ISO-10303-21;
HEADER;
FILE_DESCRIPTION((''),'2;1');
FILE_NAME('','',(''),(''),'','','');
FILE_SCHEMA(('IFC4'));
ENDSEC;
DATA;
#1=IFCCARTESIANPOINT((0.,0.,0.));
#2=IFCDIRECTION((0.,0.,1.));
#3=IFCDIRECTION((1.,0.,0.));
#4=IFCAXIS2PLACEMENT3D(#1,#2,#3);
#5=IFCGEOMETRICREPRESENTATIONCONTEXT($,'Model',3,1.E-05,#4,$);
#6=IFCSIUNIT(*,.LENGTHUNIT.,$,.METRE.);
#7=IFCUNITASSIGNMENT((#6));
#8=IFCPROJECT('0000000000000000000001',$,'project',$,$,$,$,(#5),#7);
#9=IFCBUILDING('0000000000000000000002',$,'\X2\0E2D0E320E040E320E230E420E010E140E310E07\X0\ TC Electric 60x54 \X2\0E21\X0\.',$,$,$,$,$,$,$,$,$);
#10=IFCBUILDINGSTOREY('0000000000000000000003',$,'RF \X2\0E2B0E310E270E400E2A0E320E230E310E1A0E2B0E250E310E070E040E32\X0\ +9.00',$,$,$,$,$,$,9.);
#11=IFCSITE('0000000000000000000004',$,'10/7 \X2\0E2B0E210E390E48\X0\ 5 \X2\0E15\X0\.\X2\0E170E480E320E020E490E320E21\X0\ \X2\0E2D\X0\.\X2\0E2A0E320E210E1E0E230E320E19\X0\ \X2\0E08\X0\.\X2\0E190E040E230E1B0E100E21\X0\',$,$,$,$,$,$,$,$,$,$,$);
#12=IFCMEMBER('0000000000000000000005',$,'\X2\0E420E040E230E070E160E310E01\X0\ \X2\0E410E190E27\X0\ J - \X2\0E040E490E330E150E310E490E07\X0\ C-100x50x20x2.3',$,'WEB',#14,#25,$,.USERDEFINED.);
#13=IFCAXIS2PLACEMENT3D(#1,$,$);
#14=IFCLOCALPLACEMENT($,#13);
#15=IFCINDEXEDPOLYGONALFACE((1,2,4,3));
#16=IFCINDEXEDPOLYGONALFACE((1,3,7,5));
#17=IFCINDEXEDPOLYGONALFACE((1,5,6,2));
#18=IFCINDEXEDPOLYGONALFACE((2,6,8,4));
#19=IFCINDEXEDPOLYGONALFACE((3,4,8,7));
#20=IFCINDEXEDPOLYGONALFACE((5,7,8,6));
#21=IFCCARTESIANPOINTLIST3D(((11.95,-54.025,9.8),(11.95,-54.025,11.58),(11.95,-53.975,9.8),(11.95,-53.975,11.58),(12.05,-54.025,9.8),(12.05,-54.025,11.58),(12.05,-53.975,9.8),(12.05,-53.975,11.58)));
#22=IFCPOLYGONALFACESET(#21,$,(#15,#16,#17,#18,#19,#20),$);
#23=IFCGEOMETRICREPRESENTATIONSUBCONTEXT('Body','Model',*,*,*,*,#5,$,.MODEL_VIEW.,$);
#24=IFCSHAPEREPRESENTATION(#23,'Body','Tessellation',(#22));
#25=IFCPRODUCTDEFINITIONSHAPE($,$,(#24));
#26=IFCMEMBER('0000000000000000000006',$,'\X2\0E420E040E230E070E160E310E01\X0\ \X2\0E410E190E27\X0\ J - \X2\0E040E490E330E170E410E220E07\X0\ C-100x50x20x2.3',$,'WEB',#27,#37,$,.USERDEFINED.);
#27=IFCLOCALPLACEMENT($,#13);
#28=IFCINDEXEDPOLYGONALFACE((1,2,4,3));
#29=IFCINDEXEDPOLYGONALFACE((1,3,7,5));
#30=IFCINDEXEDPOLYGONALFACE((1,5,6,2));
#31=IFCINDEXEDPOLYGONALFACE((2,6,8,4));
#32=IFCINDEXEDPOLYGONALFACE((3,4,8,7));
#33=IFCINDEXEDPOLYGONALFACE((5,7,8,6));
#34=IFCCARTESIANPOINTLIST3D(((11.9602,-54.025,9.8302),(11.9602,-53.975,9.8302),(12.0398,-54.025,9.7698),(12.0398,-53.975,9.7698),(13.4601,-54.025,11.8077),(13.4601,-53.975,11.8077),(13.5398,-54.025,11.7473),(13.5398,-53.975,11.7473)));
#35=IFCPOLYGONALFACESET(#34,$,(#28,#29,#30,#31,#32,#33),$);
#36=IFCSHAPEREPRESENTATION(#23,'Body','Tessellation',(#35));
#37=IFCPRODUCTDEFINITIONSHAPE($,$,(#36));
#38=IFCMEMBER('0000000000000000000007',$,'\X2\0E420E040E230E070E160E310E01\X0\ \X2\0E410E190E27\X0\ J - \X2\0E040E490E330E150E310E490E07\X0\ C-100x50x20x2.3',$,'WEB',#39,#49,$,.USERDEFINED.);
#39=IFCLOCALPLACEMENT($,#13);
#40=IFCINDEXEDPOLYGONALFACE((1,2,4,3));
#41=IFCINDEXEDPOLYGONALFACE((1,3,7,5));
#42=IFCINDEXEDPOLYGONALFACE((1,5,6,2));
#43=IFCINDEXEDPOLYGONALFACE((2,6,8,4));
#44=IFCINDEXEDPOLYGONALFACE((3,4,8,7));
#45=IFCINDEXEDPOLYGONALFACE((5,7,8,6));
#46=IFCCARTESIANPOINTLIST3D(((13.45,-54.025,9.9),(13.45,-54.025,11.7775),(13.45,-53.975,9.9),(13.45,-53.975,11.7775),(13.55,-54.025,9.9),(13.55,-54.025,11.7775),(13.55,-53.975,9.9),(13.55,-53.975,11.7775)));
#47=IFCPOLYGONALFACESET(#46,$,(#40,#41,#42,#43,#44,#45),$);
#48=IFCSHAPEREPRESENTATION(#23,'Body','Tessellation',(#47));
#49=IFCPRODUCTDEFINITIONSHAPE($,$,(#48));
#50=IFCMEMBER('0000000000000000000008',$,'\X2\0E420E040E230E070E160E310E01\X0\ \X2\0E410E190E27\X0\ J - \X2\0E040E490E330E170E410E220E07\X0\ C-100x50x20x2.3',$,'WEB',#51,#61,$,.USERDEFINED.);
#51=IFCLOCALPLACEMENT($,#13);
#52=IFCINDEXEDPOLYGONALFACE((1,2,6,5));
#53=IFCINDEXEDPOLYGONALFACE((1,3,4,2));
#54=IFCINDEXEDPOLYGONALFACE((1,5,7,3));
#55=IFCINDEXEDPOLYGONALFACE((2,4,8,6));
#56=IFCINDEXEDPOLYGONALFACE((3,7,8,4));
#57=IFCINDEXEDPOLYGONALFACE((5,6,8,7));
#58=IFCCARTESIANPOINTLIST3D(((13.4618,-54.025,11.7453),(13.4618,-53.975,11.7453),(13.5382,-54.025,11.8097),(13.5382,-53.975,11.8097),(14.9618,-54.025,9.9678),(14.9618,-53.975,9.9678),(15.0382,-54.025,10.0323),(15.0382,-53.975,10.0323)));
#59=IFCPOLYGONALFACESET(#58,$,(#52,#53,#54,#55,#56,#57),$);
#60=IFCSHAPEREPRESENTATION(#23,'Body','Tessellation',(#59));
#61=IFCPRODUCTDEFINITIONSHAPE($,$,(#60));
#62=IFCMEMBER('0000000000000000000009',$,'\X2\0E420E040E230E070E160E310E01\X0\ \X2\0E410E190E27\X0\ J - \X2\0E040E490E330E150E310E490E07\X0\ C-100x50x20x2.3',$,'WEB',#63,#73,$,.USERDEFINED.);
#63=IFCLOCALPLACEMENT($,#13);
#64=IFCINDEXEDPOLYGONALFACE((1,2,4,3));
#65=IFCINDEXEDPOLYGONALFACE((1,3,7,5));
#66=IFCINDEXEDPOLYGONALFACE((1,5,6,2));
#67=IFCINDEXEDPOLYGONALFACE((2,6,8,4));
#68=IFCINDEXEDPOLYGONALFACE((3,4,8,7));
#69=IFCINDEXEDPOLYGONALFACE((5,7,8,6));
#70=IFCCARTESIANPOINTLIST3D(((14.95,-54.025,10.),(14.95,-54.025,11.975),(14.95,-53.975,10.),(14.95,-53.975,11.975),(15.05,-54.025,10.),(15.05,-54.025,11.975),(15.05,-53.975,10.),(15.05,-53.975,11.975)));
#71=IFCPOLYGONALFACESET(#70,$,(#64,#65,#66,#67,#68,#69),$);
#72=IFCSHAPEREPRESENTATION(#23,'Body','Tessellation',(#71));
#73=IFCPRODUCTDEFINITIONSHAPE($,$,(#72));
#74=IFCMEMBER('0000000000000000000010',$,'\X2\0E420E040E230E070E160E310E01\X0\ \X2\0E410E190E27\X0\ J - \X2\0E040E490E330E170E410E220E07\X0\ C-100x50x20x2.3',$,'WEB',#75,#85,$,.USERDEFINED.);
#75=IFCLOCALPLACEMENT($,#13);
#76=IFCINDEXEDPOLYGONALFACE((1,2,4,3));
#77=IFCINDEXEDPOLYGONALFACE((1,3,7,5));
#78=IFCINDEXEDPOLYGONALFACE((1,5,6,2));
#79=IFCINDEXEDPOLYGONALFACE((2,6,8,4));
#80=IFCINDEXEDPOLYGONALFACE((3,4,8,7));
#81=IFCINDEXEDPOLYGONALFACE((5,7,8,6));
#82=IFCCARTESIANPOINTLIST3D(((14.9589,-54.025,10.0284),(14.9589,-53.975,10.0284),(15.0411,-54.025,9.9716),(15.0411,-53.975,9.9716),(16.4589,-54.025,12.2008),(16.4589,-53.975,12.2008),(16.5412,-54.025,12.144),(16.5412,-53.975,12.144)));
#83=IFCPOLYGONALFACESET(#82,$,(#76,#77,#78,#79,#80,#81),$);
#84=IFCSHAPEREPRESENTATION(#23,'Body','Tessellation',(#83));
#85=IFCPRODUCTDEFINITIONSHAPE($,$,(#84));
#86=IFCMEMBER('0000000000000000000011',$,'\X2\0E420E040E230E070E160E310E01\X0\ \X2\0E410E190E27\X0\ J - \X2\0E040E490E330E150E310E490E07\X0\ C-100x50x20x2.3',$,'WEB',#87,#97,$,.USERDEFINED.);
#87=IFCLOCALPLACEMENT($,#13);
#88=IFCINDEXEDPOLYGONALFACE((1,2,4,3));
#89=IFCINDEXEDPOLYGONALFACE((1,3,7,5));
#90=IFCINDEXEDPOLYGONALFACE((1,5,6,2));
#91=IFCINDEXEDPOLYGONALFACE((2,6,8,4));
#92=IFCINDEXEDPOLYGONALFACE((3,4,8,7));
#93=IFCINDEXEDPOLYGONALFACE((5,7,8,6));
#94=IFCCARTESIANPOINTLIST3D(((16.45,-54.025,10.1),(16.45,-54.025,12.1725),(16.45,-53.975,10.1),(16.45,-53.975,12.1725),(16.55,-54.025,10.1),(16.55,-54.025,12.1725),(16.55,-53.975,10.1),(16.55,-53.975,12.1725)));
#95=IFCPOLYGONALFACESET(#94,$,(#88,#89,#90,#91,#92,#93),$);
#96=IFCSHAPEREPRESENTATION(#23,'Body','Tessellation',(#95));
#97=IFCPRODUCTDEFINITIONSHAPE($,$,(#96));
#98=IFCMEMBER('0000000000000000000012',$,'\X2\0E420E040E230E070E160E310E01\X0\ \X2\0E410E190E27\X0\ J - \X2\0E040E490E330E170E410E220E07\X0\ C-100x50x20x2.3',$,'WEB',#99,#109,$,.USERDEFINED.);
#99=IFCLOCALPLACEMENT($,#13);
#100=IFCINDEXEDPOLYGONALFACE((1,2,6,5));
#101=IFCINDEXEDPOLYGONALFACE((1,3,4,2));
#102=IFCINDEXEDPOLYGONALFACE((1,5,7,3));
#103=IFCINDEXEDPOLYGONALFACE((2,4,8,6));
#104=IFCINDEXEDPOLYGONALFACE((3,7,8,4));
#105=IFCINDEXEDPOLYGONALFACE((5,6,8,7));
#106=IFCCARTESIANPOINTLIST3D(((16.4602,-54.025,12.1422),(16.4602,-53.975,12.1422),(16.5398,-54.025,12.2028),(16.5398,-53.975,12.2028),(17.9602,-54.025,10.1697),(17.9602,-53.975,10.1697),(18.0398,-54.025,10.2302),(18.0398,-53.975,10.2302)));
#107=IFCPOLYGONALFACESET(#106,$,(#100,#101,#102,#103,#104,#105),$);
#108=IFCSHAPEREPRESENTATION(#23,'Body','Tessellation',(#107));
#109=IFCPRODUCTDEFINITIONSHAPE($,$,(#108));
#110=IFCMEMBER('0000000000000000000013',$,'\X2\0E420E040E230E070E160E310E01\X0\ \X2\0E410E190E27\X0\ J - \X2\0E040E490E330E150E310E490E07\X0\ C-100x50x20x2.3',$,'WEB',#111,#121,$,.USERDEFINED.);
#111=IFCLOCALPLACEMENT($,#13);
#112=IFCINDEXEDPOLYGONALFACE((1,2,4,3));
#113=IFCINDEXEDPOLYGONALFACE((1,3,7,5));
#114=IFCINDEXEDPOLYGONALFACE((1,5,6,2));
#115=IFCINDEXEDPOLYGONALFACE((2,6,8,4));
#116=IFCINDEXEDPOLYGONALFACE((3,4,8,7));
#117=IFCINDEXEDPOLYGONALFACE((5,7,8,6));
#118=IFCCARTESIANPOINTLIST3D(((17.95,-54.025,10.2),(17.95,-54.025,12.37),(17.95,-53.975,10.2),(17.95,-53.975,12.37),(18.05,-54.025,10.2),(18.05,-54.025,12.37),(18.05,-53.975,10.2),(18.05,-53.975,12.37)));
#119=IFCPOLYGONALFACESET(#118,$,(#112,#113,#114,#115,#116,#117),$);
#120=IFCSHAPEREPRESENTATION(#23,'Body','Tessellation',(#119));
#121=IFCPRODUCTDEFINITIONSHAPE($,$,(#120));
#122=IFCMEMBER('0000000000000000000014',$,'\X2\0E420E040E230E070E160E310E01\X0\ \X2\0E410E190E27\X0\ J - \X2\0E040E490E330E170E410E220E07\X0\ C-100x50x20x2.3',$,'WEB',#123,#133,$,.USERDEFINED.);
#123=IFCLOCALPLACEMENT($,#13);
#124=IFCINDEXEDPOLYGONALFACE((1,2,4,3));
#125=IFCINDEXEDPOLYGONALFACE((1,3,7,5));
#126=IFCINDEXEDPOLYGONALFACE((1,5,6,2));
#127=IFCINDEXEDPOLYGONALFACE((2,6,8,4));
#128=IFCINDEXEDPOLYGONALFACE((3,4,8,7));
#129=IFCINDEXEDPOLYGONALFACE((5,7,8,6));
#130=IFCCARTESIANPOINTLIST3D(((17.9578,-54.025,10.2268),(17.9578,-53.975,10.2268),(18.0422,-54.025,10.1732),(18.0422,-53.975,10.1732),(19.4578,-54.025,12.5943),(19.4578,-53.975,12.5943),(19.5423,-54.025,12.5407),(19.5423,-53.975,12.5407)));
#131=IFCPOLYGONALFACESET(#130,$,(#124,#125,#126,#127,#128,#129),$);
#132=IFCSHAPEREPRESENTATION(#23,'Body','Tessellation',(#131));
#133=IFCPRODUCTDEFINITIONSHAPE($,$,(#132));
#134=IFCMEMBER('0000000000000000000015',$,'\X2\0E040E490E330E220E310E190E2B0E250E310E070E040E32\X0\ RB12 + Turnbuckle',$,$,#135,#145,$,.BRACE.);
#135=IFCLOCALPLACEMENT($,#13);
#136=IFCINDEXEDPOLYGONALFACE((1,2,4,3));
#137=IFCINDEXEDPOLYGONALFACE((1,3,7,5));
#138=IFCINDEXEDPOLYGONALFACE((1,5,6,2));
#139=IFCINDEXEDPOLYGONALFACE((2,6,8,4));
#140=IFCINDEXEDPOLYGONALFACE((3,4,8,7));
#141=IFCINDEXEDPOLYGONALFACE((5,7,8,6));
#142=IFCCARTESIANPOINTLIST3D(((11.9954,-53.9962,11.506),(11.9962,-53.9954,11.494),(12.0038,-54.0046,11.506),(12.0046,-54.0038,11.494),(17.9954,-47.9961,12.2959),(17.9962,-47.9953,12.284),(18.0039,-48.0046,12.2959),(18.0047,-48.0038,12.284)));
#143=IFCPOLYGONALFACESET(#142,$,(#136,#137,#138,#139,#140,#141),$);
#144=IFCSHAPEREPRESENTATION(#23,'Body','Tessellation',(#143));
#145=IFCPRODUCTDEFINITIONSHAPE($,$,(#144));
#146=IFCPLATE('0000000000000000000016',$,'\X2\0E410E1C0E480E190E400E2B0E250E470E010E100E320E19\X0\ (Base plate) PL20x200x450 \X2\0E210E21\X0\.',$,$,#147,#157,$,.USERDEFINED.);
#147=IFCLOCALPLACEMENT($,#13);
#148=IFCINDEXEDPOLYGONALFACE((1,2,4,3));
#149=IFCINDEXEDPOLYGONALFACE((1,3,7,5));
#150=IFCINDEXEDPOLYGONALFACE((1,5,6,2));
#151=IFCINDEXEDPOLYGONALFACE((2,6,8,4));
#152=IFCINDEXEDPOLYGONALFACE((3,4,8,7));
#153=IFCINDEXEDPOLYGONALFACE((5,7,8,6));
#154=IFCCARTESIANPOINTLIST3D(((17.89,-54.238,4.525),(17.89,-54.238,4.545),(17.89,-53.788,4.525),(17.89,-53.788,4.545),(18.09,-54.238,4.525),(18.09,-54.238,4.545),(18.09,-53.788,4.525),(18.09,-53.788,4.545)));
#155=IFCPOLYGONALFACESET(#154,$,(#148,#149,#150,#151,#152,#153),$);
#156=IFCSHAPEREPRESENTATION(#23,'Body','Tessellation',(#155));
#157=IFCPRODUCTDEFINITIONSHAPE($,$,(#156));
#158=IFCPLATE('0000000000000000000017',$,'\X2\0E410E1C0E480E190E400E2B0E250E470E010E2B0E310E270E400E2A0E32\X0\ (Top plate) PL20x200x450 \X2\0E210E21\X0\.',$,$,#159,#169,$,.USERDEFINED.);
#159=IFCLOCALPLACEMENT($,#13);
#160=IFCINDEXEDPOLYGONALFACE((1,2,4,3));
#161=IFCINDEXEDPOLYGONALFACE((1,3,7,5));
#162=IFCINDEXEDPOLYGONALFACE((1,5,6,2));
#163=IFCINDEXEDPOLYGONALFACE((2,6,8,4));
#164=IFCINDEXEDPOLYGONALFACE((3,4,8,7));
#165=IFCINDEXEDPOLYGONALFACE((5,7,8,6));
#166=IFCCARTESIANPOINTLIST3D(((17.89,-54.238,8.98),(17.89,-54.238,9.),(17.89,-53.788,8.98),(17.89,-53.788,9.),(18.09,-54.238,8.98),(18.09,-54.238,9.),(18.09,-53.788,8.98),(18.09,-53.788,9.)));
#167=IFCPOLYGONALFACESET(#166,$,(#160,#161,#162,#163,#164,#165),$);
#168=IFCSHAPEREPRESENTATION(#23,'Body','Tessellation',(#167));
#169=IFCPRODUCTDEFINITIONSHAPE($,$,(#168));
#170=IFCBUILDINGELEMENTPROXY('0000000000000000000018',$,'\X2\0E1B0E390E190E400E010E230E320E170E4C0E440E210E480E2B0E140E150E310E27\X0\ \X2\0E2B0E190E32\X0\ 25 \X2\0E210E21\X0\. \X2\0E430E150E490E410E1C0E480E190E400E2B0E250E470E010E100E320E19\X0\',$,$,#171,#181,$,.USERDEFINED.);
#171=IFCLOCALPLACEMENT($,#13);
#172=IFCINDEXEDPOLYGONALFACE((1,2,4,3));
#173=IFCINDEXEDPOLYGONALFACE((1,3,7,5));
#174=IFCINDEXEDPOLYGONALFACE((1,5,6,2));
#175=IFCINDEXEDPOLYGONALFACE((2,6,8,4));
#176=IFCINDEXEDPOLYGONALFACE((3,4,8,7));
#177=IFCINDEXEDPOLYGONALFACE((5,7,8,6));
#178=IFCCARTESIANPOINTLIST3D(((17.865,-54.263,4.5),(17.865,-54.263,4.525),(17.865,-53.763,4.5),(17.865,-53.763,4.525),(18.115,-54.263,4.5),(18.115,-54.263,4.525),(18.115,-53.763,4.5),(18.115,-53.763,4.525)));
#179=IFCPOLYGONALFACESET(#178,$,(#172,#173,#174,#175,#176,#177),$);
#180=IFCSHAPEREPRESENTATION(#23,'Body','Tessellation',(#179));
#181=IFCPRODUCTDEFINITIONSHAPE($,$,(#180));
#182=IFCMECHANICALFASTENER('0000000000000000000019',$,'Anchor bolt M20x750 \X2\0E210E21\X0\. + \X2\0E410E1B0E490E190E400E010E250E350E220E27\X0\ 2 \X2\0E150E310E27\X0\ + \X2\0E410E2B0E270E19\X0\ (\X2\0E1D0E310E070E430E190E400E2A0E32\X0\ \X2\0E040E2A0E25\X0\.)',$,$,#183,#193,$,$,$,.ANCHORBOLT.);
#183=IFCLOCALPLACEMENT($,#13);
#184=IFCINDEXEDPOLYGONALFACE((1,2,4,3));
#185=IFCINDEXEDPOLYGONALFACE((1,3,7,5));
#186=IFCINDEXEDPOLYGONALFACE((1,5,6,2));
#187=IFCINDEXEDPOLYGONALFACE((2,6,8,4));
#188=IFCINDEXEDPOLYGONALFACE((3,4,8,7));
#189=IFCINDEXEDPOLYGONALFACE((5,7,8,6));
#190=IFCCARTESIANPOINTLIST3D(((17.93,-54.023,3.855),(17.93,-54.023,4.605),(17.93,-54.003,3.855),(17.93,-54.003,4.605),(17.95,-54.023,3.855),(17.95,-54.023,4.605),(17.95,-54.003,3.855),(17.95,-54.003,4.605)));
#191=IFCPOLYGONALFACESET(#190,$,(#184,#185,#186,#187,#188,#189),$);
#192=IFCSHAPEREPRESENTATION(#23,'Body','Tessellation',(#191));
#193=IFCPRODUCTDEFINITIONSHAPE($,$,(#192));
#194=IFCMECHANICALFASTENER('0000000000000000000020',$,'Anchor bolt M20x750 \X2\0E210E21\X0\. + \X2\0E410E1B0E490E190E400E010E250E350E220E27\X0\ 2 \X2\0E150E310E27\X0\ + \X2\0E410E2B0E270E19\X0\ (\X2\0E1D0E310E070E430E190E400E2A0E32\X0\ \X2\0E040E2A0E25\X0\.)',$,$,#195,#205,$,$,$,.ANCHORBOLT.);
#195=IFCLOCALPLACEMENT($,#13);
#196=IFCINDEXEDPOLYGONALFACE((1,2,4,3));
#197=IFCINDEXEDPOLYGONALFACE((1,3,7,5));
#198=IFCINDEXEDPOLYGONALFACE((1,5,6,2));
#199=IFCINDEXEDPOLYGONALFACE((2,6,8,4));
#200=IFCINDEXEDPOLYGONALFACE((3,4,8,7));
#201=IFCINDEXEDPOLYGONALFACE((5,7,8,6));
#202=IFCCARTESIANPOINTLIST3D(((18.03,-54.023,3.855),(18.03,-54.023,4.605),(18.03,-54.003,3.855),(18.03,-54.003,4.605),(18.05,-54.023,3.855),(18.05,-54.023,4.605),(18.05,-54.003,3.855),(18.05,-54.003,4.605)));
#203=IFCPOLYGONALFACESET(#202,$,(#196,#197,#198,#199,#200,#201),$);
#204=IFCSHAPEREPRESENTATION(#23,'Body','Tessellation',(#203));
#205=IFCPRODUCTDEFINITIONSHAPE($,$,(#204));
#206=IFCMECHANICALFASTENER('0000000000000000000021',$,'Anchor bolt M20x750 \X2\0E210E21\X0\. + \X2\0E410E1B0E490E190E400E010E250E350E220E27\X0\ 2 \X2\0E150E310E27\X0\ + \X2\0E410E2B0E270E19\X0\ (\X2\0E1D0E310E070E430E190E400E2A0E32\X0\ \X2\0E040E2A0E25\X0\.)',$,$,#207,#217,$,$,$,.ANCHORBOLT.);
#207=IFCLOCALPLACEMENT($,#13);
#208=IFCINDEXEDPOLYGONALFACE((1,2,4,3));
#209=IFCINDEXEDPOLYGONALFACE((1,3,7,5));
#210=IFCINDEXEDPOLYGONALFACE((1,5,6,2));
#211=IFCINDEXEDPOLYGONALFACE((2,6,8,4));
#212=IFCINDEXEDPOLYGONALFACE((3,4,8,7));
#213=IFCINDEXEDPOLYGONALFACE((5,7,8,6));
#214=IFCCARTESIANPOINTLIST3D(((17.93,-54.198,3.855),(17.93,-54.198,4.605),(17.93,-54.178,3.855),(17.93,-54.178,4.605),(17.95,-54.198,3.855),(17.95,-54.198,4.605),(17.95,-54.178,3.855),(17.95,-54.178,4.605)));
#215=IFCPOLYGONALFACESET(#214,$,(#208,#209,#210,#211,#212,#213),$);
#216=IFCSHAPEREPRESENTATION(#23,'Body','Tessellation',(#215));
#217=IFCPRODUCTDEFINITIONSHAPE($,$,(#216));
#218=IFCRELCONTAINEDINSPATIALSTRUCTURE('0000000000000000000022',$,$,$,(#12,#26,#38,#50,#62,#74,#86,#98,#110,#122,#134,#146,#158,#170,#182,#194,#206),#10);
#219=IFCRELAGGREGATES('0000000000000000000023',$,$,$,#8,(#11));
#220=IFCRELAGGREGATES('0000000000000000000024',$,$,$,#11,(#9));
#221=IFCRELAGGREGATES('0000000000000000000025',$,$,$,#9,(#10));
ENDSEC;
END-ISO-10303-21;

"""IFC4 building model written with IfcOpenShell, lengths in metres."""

from ifc_helpers import new_model, si_unit, frame, origin, origin_with_axes, origin_2d, place, context, subcontext, project, spatial, rectangle, extrude, element, save


model = new_model("IFC4")

# Units and contexts
model_context = context("Model", 3, precision=1e-05, world=origin_with_axes())
body_context = subcontext(model_context, "Body", "Model", "MODEL_VIEW")
ifc_project = project(units=[si_unit("LENGTHUNIT", "METRE")], contexts=[model_context])

# Site, building, storey
site = spatial("IfcSite", under=ifc_project, Name="10/7 หมู่ 5 ต.ท่าข้าม อ.สามพราน จ.นครปฐม")
building = spatial("IfcBuilding", under=site, Name="อาคารโกดัง TC Electric 60x54 ม.")
storey = spatial("IfcBuildingStorey", under=building, Name="RF หัวเสารับหลังคา +9.00", Elevation=9.0)

# Members
member_1_placement = place(None, frame((12.0, -54.0, 9.8), z_axis=(0.0, 0.0, 1.0), x_axis=(0.0, 1.0, 0.0)))
element("IfcMember", 1, at=member_1_placement, inside=storey, Name="โครงถัก แนว J - ค้ำตั้ง C-100x50x20x2.3", ObjectType="WEB", PredefinedType="USERDEFINED", context=body_context, shape_type="SweptSolid", body=[
    extrude(rectangle(XDim=0.05, YDim=0.1, at=origin_2d()), origin(), (0.0, 0.0, 1.0), 1.78),
])
member_2_placement = place(None, frame((12.0, -54.0, 9.8), z_axis=(0.6043, 0.0, 0.7967), x_axis=(0.0, -1.0, 0.0)))
element("IfcMember", 2, at=member_2_placement, inside=storey, Name="โครงถัก แนว J - ค้ำทแยง C-100x50x20x2.3", ObjectType="WEB", PredefinedType="USERDEFINED", context=body_context, shape_type="SweptSolid", body=[
    extrude(rectangle(XDim=0.05, YDim=0.1, at=origin_2d()), origin(), (0.0, 0.0, 1.0), 2.482),
])
member_3_placement = place(None, frame((13.5, -54.0, 9.9), z_axis=(0.0, 0.0, 1.0), x_axis=(0.0, 1.0, 0.0)))
element("IfcMember", 3, at=member_3_placement, inside=storey, Name="โครงถัก แนว J - ค้ำตั้ง C-100x50x20x2.3", ObjectType="WEB", PredefinedType="USERDEFINED", context=body_context, shape_type="SweptSolid", body=[
    extrude(rectangle(XDim=0.05, YDim=0.1, at=origin_2d()), origin(), (0.0, 0.0, 1.0), 1.8775),
])
member_4_placement = place(None, frame((13.5, -54.0, 11.7775), z_axis=(0.6449, 0.0, -0.7642), x_axis=(0.0, -1.0, 0.0)))
element("IfcMember", 4, at=member_4_placement, inside=storey, Name="โครงถัก แนว J - ค้ำทแยง C-100x50x20x2.3", ObjectType="WEB", PredefinedType="USERDEFINED", context=body_context, shape_type="SweptSolid", body=[
    extrude(rectangle(XDim=0.05, YDim=0.1, at=origin_2d()), origin(), (0.0, 0.0, 1.0), 2.3258),
])
member_5_placement = place(None, frame((15.0, -54.0, 10.0), z_axis=(0.0, 0.0, 1.0), x_axis=(0.0, 1.0, 0.0)))
element("IfcMember", 5, at=member_5_placement, inside=storey, Name="โครงถัก แนว J - ค้ำตั้ง C-100x50x20x2.3", ObjectType="WEB", PredefinedType="USERDEFINED", context=body_context, shape_type="SweptSolid", body=[
    extrude(rectangle(XDim=0.05, YDim=0.1, at=origin_2d()), origin(), (0.0, 0.0, 1.0), 1.975),
])
member_6_placement = place(None, frame((15.0, -54.0, 10.0), z_axis=(0.5682, 0.0, 0.8229), x_axis=(0.0, -1.0, 0.0)))
element("IfcMember", 6, at=member_6_placement, inside=storey, Name="โครงถัก แนว J - ค้ำทแยง C-100x50x20x2.3", ObjectType="WEB", PredefinedType="USERDEFINED", context=body_context, shape_type="SweptSolid", body=[
    extrude(rectangle(XDim=0.05, YDim=0.1, at=origin_2d()), origin(), (0.0, 0.0, 1.0), 2.64),
])
member_7_placement = place(None, frame((16.5, -54.0, 10.1), z_axis=(0.0, 0.0, 1.0), x_axis=(0.0, 1.0, 0.0)))
element("IfcMember", 7, at=member_7_placement, inside=storey, Name="โครงถัก แนว J - ค้ำตั้ง C-100x50x20x2.3", ObjectType="WEB", PredefinedType="USERDEFINED", context=body_context, shape_type="SweptSolid", body=[
    extrude(rectangle(XDim=0.05, YDim=0.1, at=origin_2d()), origin(), (0.0, 0.0, 1.0), 2.0725),
])
member_8_placement = place(None, frame((16.5, -54.0, 12.1725), z_axis=(0.6053, 0.0, -0.796), x_axis=(0.0, -1.0, 0.0)))
element("IfcMember", 8, at=member_8_placement, inside=storey, Name="โครงถัก แนว J - ค้ำทแยง C-100x50x20x2.3", ObjectType="WEB", PredefinedType="USERDEFINED", context=body_context, shape_type="SweptSolid", body=[
    extrude(rectangle(XDim=0.05, YDim=0.1, at=origin_2d()), origin(), (0.0, 0.0, 1.0), 2.4781),
])
member_9_placement = place(None, frame((18.0, -54.0, 10.2), z_axis=(0.0, 0.0, 1.0), x_axis=(0.0, 1.0, 0.0)))
element("IfcMember", 9, at=member_9_placement, inside=storey, Name="โครงถัก แนว J - ค้ำตั้ง C-100x50x20x2.3", ObjectType="WEB", PredefinedType="USERDEFINED", context=body_context, shape_type="SweptSolid", body=[
    extrude(rectangle(XDim=0.05, YDim=0.1, at=origin_2d()), origin(), (0.0, 0.0, 1.0), 2.17),
])
member_10_placement = place(None, frame((18.0, -54.0, 10.2), z_axis=(0.5352, 0.0, 0.8447), x_axis=(0.0, -1.0, 0.0)))
element("IfcMember", 10, at=member_10_placement, inside=storey, Name="โครงถัก แนว J - ค้ำทแยง C-100x50x20x2.3", ObjectType="WEB", PredefinedType="USERDEFINED", context=body_context, shape_type="SweptSolid", body=[
    extrude(rectangle(XDim=0.05, YDim=0.1, at=origin_2d()), origin(), (0.0, 0.0, 1.0), 2.8027),
])
member_11_placement = place(None, frame((12.0, -54.0, 11.5), z_axis=(0.7041, 0.7041, 0.0927), x_axis=(0.7071, -0.7071, 0.0)))
element("IfcMember", 11, at=member_11_placement, inside=storey, Name="ค้ำยันหลังคา RB12 + Turnbuckle", PredefinedType="BRACE", context=body_context, shape_type="SweptSolid", body=[
    extrude(rectangle(XDim=0.012, YDim=0.012, at=origin_2d()), origin(), (0.0, 0.0, 1.0), 8.522),
])

# Plates
for number, where, z_axis, x_axis, name in (
    (12, (17.99, -54.013, 4.525), (0.0, 0.0, 1.0), (1.0, 0.0, 0.0), "แผ่นเหล็กฐาน (Base plate) PL20x200x450 มม."),
    (13, (17.99, -54.013, 8.98), (0.0, 0.0, 1.0), (1.0, 0.0, 0.0), "แผ่นเหล็กหัวเสา (Top plate) PL20x200x450 มม."),
):
    element("IfcPlate", number, at=place(None, frame(where, z_axis=z_axis, x_axis=x_axis)), inside=storey, Name=name, PredefinedType="USERDEFINED", context=body_context, shape_type="SweptSolid", body=[
        extrude(rectangle(XDim=0.2, YDim=0.45, at=origin_2d()), origin(), (0.0, 0.0, 1.0), 0.02),
    ])

# Building element proxy
proxy_1_placement = place(None, frame((17.99, -54.013, 4.5), z_axis=(0.0, 0.0, 1.0), x_axis=(1.0, 0.0, 0.0)))
element("IfcBuildingElementProxy", 14, at=proxy_1_placement, inside=storey, Name="ปูนเกราท์ไม่หดตัว หนา 25 มม. ใต้แผ่นเหล็กฐาน", PredefinedType="USERDEFINED", context=body_context, shape_type="SweptSolid", body=[
    extrude(rectangle(XDim=0.25, YDim=0.5, at=origin_2d()), origin(), (0.0, 0.0, 1.0), 0.025),
])

# Mechanical fasteners
for number, where, z_axis, x_axis, name in (
    (15, (17.94, -54.013, 3.855), (0.0, 0.0, 1.0), (1.0, 0.0, 0.0), "Anchor bolt M20x750 มม. + แป้นเกลียว 2 ตัว + แหวน (ฝังในเสา คสล.)"),
    (16, (18.04, -54.013, 3.855), (0.0, 0.0, 1.0), (1.0, 0.0, 0.0), "Anchor bolt M20x750 มม. + แป้นเกลียว 2 ตัว + แหวน (ฝังในเสา คสล.)"),
    (17, (17.94, -54.188, 3.855), (0.0, 0.0, 1.0), (1.0, 0.0, 0.0), "Anchor bolt M20x750 มม. + แป้นเกลียว 2 ตัว + แหวน (ฝังในเสา คสล.)"),
):
    element("IfcMechanicalFastener", number, at=place(None, frame(where, z_axis=z_axis, x_axis=x_axis)), inside=storey, Name=name, PredefinedType="ANCHORBOLT", context=body_context, shape_type="SweptSolid", body=[
        extrude(rectangle(XDim=0.02, YDim=0.02, at=origin_2d()), origin(), (0.0, 0.0, 1.0), 0.75),
    ])

save(model, "model.ifc")
